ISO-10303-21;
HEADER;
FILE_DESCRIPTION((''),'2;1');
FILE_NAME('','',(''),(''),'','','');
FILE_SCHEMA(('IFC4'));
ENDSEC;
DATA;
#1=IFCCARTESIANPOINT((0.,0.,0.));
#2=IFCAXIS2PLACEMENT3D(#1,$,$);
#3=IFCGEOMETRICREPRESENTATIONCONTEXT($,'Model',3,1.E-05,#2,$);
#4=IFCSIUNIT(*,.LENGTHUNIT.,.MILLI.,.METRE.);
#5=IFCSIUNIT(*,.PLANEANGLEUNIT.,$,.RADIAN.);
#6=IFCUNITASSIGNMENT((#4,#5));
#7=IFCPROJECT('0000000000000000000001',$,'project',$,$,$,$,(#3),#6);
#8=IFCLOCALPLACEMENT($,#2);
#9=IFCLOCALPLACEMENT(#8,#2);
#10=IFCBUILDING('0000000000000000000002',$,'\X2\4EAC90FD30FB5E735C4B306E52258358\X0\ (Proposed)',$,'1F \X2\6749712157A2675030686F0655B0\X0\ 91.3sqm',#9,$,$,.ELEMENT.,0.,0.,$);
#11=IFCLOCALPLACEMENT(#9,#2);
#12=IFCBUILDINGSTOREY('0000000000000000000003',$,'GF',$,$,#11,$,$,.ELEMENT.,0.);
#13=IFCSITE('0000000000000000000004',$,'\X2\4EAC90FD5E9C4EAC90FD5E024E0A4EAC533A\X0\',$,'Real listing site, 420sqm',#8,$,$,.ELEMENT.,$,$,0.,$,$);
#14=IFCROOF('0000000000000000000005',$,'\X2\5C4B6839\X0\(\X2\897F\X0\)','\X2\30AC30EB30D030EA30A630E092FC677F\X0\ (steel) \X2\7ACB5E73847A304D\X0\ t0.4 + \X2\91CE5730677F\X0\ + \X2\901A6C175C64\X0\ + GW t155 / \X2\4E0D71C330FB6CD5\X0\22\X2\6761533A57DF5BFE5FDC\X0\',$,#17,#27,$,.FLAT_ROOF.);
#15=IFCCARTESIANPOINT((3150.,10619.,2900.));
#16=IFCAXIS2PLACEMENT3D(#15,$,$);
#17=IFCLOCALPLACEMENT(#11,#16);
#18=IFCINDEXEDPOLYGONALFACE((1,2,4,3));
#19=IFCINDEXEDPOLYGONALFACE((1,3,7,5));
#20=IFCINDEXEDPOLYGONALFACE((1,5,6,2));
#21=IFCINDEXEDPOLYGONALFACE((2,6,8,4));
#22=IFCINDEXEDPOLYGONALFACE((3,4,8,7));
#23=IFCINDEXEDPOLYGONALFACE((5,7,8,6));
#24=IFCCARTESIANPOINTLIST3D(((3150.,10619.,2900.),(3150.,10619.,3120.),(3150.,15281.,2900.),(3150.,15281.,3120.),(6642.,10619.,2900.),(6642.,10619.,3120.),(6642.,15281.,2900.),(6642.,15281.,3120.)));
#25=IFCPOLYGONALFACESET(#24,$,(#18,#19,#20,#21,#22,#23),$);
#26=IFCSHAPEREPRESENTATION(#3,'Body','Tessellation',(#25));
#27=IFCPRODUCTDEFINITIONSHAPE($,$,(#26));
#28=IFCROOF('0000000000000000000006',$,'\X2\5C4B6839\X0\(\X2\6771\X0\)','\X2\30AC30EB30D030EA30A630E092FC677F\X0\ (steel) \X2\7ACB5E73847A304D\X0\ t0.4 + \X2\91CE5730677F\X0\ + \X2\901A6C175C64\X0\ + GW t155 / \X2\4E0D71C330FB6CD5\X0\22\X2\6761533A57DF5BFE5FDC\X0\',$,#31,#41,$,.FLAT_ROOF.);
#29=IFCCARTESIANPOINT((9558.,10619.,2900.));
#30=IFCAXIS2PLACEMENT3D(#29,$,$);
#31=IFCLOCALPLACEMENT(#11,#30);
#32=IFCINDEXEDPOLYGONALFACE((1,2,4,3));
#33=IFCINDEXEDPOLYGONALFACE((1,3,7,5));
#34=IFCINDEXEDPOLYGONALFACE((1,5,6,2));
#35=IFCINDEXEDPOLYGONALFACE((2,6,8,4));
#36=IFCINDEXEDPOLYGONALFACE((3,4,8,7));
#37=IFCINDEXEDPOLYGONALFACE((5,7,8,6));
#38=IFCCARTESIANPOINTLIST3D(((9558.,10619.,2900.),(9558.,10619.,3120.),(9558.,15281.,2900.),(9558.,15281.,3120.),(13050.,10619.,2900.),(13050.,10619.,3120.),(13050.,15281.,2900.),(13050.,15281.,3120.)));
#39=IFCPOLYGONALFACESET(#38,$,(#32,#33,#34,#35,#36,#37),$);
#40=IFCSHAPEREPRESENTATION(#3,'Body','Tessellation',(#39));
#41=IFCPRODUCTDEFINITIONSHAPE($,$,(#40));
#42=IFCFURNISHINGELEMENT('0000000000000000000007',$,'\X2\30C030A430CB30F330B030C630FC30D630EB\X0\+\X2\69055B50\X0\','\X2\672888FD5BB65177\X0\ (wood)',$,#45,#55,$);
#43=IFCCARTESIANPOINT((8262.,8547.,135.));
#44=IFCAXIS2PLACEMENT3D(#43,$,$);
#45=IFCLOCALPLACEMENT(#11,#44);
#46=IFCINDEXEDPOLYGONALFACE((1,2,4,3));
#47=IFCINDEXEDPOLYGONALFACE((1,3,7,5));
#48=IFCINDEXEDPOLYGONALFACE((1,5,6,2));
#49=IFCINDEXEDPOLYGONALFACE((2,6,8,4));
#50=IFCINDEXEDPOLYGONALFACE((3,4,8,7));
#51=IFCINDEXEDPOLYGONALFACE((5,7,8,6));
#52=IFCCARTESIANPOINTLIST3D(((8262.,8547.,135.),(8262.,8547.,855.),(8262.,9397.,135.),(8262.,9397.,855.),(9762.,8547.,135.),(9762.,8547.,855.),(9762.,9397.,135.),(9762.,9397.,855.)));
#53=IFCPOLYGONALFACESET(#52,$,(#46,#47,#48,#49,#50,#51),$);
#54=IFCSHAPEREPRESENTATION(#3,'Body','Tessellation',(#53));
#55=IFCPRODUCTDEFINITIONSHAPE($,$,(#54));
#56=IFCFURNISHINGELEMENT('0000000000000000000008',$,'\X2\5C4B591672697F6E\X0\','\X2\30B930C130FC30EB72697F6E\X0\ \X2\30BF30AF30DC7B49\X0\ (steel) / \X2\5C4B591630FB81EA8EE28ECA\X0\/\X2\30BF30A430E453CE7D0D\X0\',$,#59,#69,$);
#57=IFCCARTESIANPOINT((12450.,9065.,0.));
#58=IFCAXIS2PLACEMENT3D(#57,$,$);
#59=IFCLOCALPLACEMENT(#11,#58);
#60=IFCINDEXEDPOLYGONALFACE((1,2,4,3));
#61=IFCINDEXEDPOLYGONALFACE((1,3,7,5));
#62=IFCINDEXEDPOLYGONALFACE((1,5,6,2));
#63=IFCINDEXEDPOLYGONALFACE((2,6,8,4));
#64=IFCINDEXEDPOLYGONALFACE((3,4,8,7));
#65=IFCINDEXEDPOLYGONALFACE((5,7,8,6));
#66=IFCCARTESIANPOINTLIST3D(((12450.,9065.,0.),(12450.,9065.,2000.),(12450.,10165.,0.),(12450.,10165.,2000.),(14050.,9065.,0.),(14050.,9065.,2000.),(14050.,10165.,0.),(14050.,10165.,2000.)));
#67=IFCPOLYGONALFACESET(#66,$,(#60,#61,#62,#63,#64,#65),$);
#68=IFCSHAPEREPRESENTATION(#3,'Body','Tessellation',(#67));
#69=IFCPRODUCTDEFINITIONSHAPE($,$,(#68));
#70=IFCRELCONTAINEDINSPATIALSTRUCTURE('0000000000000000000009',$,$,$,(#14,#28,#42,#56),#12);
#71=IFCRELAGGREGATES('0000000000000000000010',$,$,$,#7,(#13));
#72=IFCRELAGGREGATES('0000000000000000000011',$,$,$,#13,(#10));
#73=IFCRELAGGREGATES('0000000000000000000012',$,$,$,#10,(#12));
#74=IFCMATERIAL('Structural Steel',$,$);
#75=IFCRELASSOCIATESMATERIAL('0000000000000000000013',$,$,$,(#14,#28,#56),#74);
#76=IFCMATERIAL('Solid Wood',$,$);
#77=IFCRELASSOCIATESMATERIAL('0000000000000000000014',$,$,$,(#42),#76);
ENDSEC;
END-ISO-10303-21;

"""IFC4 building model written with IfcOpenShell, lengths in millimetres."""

from ifc_helpers import new_model, si_unit, frame, frame_2d, origin, place, context, project, spatial, rectangle, extrude, material, element, save


model = new_model("IFC4")

# Units and contexts
model_context = context("Model", 3, precision=1e-05, world=origin())
ifc_project = project(units=[si_unit("LENGTHUNIT", "METRE", prefix="MILLI"), si_unit("PLANEANGLEUNIT", "RADIAN")], contexts=[model_context])

# Site, building, storey
site_placement = place(None, origin())
site = spatial("IfcSite", under=ifc_project, at=site_placement, Name="京都府京都市上京区", ObjectType="Real listing site, 420sqm", CompositionType="ELEMENT", RefElevation=0.0)
building_placement = place(site_placement, origin())
building = spatial("IfcBuilding", under=site, at=building_placement, Name="京都・平屋の別荘 (Proposed)", ObjectType="1F 杉無垢材と漆喰 91.3sqm", CompositionType="ELEMENT", ElevationOfRefHeight=0.0, ElevationOfTerrain=0.0)
storey_placement = place(building_placement, origin())
storey = spatial("IfcBuildingStorey", under=building, at=storey_placement, Name="GF", CompositionType="ELEMENT", Elevation=0.0)

# Shared definitions
ifc_material_1 = material(Name="Solid Wood")

# Roofs
ifc_material_2 = material(Name="Structural Steel")
roof_1_placement = place(storey_placement, frame((3150.0, 10619.0, 2900.0)))
element("IfcRoof", 1, at=roof_1_placement, inside=storey, material=ifc_material_2, Name="屋根(西)", Description="ガルバリウム鋼板 (steel) 立平葺き t0.4 + 野地板 + 通気層 + GW t155 / 不燃・法22条区域対応", PredefinedType="FLAT_ROOF", context=model_context, shape_type="SweptSolid", body=[
    extrude(rectangle(XDim=3492.0, YDim=4662.0, at=frame_2d((1746.0, 2331.0))), frame((3150.0, 10619.0, 2900.0)), (0.0, 0.0, 1.0), 220.0),
])
roof_2_placement = place(storey_placement, frame((9558.0, 10619.0, 2900.0)))
element("IfcRoof", 2, at=roof_2_placement, inside=storey, material=ifc_material_2, Name="屋根(東)", Description="ガルバリウム鋼板 (steel) 立平葺き t0.4 + 野地板 + 通気層 + GW t155 / 不燃・法22条区域対応", PredefinedType="FLAT_ROOF", context=model_context, shape_type="SweptSolid", body=[
    extrude(rectangle(XDim=3492.0, YDim=4662.0, at=frame_2d((1746.0, 2331.0))), frame((9558.0, 10619.0, 2900.0)), (0.0, 0.0, 1.0), 220.0),
])

# Furnishing elements
furnishing_1_placement = place(storey_placement, frame((8262.0, 8547.0, 135.0)))
element("IfcFurnishingElement", 3, at=furnishing_1_placement, inside=storey, material=ifc_material_1, Name="ダイニングテーブル+椅子", Description="木製家具 (wood)", context=model_context, shape_type="SweptSolid", body=[
    extrude(rectangle(XDim=1500.0, YDim=850.0, at=frame_2d((750.0, 425.0))), frame((8262.0, 8547.0, 135.0)), (0.0, 0.0, 1.0), 720.0),
])
furnishing_2_placement = place(storey_placement, frame((12450.0, 9065.0, 0.0)))
element("IfcFurnishingElement", 4, at=furnishing_2_placement, inside=storey, material=ifc_material_2, Name="屋外物置", Description="スチール物置 タクボ等 (steel) / 屋外・自転車/タイヤ収納", context=model_context, shape_type="SweptSolid", body=[
    extrude(rectangle(XDim=1600.0, YDim=1100.0, at=frame_2d((800.0, 550.0))), frame((12450.0, 9065.0, 0.0)), (0.0, 0.0, 1.0), 2000.0),
])

save(model, "model.ifc")
